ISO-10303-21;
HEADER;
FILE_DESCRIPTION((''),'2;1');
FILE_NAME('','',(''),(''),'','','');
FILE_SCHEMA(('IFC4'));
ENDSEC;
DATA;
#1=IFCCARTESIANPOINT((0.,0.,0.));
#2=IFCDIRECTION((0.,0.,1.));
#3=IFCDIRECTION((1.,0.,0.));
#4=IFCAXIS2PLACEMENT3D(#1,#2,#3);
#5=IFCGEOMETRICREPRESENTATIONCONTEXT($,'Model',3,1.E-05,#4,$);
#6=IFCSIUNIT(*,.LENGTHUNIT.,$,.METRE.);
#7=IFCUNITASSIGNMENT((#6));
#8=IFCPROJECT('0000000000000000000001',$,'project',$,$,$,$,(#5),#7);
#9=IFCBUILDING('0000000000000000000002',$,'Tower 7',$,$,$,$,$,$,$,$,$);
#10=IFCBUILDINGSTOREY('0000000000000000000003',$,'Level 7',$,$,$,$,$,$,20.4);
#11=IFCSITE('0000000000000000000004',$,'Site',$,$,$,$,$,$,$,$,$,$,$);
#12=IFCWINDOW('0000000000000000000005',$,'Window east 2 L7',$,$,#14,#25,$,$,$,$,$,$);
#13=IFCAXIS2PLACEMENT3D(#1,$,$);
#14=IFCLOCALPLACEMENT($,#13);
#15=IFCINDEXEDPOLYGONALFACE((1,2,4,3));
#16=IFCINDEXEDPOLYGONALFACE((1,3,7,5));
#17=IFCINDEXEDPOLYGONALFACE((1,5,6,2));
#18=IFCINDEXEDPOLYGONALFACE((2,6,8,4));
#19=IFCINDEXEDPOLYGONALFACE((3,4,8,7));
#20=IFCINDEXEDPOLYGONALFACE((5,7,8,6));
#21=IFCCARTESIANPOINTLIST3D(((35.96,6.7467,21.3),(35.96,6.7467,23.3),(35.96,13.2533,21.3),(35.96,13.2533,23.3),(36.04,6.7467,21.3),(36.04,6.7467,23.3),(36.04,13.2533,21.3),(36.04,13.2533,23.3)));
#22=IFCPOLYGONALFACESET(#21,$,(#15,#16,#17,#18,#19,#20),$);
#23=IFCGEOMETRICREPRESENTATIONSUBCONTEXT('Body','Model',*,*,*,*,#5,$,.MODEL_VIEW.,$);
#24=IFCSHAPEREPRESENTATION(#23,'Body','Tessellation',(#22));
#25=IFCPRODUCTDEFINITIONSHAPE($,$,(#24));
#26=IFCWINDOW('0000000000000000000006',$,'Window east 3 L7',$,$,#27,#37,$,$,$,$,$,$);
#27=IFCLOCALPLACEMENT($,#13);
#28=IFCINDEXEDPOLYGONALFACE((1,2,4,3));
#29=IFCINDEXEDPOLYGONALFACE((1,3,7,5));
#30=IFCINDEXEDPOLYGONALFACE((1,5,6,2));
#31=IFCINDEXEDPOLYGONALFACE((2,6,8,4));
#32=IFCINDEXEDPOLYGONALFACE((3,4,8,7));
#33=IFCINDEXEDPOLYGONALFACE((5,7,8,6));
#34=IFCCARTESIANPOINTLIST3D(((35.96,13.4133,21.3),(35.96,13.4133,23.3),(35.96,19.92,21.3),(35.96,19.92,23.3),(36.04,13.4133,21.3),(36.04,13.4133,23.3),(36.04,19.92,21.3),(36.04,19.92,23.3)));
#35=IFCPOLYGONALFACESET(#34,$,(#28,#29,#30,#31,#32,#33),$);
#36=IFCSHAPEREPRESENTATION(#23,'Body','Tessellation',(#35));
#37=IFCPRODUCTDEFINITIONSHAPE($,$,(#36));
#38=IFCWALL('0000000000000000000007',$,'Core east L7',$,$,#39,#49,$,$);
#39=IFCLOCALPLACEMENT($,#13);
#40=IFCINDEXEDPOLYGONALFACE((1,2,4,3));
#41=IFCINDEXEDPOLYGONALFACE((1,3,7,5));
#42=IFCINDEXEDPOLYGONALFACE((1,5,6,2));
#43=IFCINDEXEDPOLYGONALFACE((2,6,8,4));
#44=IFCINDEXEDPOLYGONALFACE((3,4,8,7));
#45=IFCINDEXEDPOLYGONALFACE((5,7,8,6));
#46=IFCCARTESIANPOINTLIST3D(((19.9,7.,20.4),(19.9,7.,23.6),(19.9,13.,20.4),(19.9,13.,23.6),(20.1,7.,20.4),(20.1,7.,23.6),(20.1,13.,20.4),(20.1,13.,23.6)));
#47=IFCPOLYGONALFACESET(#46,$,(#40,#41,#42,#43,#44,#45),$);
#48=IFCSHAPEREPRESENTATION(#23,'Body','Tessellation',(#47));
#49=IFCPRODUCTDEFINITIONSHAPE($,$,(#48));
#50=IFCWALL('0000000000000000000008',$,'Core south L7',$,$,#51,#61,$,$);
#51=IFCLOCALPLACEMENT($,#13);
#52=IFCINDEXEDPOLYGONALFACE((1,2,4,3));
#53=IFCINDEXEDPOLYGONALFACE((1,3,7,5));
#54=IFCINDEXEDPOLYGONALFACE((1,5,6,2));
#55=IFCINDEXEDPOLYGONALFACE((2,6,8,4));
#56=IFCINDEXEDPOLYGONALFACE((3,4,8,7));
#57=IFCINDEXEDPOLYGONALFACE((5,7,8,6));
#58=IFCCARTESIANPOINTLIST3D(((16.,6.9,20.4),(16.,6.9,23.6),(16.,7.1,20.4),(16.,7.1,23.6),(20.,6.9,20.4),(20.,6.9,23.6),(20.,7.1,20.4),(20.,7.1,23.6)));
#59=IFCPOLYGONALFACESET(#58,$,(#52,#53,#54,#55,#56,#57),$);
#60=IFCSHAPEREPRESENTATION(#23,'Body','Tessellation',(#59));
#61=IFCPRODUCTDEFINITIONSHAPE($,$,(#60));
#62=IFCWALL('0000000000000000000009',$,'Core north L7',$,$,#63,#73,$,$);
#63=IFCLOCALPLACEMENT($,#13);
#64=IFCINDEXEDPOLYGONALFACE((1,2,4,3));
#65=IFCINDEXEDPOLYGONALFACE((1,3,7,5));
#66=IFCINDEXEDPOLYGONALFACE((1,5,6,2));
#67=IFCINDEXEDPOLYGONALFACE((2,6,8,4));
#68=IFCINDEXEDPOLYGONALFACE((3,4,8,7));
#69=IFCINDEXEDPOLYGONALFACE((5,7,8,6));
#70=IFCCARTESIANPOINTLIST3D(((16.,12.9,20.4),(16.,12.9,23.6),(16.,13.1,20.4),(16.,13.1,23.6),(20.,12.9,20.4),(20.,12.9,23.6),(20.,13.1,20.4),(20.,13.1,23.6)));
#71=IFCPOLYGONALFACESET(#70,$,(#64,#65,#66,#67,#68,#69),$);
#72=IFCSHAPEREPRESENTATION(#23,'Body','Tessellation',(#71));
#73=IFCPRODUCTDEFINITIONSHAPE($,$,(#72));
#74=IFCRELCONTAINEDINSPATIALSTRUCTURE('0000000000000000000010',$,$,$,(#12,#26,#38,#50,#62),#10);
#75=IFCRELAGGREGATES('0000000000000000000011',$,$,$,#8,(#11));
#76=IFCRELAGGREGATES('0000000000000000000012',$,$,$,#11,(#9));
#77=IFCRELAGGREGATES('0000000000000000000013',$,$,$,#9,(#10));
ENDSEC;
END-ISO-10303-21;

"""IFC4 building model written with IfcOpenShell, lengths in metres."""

from ifc_helpers import new_model, si_unit, frame, origin, origin_with_axes, origin_2d, place, context, subcontext, project, spatial, rectangle, extrude, element, save


model = new_model("IFC4")

# Units and contexts
model_context = context("Model", 3, precision=1e-05, world=origin_with_axes())
body_context = subcontext(model_context, "Body", "Model", "MODEL_VIEW")
ifc_project = project(units=[si_unit("LENGTHUNIT", "METRE")], contexts=[model_context])

# Site, building, storey
site = spatial("IfcSite", under=ifc_project, Name="Site")
building = spatial("IfcBuilding", under=site, Name="Tower 7")
storey = spatial("IfcBuildingStorey", under=building, Name="Level 7", Elevation=20.4)

# Windows
for number, where, z_axis, x_axis, name in (
    (1, (36.0, 10.0, 21.3), (0.0, 0.0, 1.0), (1.0, 0.0, 0.0), "Window east 2 L7"),
):
    element("IfcWindow", number, at=place(None, frame(where, z_axis=z_axis, x_axis=x_axis)), inside=storey, Name=name, context=body_context, shape_type="SweptSolid", body=[
        extrude(rectangle(XDim=0.08, YDim=6.5067, at=origin_2d()), origin(), (0.0, 0.0, 1.0), 2.0),
    ])
window_placement = place(None, frame((36.0, 16.6667, 21.3), z_axis=(0.0, 0.0, 1.0), x_axis=(1.0, 0.0, 0.0)))
element("IfcWindow", 2, at=window_placement, inside=storey, Name="Window east 3 L7", context=body_context, shape_type="SweptSolid", body=[
    extrude(rectangle(XDim=0.08, YDim=6.5067, at=origin_2d()), origin(), (0.0, 0.0, 1.0), 2.0),
])

# Walls
wall_1_placement = place(None, frame((20.0, 10.0, 20.4), z_axis=(0.0, 0.0, 1.0), x_axis=(1.0, 0.0, 0.0)))
element("IfcWall", 3, at=wall_1_placement, inside=storey, Name="Core east L7", context=body_context, shape_type="SweptSolid", body=[
    extrude(rectangle(XDim=0.2, YDim=6.0, at=origin_2d()), origin(), (0.0, 0.0, 1.0), 3.2),
])
for number, where, z_axis, x_axis, name in (
    (4, (18.0, 7.0, 20.4), (0.0, 0.0, 1.0), (1.0, 0.0, 0.0), "Core south L7"),
    (5, (18.0, 13.0, 20.4), (0.0, 0.0, 1.0), (1.0, 0.0, 0.0), "Core north L7"),
):
    element("IfcWall", number, at=place(None, frame(where, z_axis=z_axis, x_axis=x_axis)), inside=storey, Name=name, context=body_context, shape_type="SweptSolid", body=[
        extrude(rectangle(XDim=4.0, YDim=0.2, at=origin_2d()), origin(), (0.0, 0.0, 1.0), 3.2),
    ])

save(model, "model.ifc")
